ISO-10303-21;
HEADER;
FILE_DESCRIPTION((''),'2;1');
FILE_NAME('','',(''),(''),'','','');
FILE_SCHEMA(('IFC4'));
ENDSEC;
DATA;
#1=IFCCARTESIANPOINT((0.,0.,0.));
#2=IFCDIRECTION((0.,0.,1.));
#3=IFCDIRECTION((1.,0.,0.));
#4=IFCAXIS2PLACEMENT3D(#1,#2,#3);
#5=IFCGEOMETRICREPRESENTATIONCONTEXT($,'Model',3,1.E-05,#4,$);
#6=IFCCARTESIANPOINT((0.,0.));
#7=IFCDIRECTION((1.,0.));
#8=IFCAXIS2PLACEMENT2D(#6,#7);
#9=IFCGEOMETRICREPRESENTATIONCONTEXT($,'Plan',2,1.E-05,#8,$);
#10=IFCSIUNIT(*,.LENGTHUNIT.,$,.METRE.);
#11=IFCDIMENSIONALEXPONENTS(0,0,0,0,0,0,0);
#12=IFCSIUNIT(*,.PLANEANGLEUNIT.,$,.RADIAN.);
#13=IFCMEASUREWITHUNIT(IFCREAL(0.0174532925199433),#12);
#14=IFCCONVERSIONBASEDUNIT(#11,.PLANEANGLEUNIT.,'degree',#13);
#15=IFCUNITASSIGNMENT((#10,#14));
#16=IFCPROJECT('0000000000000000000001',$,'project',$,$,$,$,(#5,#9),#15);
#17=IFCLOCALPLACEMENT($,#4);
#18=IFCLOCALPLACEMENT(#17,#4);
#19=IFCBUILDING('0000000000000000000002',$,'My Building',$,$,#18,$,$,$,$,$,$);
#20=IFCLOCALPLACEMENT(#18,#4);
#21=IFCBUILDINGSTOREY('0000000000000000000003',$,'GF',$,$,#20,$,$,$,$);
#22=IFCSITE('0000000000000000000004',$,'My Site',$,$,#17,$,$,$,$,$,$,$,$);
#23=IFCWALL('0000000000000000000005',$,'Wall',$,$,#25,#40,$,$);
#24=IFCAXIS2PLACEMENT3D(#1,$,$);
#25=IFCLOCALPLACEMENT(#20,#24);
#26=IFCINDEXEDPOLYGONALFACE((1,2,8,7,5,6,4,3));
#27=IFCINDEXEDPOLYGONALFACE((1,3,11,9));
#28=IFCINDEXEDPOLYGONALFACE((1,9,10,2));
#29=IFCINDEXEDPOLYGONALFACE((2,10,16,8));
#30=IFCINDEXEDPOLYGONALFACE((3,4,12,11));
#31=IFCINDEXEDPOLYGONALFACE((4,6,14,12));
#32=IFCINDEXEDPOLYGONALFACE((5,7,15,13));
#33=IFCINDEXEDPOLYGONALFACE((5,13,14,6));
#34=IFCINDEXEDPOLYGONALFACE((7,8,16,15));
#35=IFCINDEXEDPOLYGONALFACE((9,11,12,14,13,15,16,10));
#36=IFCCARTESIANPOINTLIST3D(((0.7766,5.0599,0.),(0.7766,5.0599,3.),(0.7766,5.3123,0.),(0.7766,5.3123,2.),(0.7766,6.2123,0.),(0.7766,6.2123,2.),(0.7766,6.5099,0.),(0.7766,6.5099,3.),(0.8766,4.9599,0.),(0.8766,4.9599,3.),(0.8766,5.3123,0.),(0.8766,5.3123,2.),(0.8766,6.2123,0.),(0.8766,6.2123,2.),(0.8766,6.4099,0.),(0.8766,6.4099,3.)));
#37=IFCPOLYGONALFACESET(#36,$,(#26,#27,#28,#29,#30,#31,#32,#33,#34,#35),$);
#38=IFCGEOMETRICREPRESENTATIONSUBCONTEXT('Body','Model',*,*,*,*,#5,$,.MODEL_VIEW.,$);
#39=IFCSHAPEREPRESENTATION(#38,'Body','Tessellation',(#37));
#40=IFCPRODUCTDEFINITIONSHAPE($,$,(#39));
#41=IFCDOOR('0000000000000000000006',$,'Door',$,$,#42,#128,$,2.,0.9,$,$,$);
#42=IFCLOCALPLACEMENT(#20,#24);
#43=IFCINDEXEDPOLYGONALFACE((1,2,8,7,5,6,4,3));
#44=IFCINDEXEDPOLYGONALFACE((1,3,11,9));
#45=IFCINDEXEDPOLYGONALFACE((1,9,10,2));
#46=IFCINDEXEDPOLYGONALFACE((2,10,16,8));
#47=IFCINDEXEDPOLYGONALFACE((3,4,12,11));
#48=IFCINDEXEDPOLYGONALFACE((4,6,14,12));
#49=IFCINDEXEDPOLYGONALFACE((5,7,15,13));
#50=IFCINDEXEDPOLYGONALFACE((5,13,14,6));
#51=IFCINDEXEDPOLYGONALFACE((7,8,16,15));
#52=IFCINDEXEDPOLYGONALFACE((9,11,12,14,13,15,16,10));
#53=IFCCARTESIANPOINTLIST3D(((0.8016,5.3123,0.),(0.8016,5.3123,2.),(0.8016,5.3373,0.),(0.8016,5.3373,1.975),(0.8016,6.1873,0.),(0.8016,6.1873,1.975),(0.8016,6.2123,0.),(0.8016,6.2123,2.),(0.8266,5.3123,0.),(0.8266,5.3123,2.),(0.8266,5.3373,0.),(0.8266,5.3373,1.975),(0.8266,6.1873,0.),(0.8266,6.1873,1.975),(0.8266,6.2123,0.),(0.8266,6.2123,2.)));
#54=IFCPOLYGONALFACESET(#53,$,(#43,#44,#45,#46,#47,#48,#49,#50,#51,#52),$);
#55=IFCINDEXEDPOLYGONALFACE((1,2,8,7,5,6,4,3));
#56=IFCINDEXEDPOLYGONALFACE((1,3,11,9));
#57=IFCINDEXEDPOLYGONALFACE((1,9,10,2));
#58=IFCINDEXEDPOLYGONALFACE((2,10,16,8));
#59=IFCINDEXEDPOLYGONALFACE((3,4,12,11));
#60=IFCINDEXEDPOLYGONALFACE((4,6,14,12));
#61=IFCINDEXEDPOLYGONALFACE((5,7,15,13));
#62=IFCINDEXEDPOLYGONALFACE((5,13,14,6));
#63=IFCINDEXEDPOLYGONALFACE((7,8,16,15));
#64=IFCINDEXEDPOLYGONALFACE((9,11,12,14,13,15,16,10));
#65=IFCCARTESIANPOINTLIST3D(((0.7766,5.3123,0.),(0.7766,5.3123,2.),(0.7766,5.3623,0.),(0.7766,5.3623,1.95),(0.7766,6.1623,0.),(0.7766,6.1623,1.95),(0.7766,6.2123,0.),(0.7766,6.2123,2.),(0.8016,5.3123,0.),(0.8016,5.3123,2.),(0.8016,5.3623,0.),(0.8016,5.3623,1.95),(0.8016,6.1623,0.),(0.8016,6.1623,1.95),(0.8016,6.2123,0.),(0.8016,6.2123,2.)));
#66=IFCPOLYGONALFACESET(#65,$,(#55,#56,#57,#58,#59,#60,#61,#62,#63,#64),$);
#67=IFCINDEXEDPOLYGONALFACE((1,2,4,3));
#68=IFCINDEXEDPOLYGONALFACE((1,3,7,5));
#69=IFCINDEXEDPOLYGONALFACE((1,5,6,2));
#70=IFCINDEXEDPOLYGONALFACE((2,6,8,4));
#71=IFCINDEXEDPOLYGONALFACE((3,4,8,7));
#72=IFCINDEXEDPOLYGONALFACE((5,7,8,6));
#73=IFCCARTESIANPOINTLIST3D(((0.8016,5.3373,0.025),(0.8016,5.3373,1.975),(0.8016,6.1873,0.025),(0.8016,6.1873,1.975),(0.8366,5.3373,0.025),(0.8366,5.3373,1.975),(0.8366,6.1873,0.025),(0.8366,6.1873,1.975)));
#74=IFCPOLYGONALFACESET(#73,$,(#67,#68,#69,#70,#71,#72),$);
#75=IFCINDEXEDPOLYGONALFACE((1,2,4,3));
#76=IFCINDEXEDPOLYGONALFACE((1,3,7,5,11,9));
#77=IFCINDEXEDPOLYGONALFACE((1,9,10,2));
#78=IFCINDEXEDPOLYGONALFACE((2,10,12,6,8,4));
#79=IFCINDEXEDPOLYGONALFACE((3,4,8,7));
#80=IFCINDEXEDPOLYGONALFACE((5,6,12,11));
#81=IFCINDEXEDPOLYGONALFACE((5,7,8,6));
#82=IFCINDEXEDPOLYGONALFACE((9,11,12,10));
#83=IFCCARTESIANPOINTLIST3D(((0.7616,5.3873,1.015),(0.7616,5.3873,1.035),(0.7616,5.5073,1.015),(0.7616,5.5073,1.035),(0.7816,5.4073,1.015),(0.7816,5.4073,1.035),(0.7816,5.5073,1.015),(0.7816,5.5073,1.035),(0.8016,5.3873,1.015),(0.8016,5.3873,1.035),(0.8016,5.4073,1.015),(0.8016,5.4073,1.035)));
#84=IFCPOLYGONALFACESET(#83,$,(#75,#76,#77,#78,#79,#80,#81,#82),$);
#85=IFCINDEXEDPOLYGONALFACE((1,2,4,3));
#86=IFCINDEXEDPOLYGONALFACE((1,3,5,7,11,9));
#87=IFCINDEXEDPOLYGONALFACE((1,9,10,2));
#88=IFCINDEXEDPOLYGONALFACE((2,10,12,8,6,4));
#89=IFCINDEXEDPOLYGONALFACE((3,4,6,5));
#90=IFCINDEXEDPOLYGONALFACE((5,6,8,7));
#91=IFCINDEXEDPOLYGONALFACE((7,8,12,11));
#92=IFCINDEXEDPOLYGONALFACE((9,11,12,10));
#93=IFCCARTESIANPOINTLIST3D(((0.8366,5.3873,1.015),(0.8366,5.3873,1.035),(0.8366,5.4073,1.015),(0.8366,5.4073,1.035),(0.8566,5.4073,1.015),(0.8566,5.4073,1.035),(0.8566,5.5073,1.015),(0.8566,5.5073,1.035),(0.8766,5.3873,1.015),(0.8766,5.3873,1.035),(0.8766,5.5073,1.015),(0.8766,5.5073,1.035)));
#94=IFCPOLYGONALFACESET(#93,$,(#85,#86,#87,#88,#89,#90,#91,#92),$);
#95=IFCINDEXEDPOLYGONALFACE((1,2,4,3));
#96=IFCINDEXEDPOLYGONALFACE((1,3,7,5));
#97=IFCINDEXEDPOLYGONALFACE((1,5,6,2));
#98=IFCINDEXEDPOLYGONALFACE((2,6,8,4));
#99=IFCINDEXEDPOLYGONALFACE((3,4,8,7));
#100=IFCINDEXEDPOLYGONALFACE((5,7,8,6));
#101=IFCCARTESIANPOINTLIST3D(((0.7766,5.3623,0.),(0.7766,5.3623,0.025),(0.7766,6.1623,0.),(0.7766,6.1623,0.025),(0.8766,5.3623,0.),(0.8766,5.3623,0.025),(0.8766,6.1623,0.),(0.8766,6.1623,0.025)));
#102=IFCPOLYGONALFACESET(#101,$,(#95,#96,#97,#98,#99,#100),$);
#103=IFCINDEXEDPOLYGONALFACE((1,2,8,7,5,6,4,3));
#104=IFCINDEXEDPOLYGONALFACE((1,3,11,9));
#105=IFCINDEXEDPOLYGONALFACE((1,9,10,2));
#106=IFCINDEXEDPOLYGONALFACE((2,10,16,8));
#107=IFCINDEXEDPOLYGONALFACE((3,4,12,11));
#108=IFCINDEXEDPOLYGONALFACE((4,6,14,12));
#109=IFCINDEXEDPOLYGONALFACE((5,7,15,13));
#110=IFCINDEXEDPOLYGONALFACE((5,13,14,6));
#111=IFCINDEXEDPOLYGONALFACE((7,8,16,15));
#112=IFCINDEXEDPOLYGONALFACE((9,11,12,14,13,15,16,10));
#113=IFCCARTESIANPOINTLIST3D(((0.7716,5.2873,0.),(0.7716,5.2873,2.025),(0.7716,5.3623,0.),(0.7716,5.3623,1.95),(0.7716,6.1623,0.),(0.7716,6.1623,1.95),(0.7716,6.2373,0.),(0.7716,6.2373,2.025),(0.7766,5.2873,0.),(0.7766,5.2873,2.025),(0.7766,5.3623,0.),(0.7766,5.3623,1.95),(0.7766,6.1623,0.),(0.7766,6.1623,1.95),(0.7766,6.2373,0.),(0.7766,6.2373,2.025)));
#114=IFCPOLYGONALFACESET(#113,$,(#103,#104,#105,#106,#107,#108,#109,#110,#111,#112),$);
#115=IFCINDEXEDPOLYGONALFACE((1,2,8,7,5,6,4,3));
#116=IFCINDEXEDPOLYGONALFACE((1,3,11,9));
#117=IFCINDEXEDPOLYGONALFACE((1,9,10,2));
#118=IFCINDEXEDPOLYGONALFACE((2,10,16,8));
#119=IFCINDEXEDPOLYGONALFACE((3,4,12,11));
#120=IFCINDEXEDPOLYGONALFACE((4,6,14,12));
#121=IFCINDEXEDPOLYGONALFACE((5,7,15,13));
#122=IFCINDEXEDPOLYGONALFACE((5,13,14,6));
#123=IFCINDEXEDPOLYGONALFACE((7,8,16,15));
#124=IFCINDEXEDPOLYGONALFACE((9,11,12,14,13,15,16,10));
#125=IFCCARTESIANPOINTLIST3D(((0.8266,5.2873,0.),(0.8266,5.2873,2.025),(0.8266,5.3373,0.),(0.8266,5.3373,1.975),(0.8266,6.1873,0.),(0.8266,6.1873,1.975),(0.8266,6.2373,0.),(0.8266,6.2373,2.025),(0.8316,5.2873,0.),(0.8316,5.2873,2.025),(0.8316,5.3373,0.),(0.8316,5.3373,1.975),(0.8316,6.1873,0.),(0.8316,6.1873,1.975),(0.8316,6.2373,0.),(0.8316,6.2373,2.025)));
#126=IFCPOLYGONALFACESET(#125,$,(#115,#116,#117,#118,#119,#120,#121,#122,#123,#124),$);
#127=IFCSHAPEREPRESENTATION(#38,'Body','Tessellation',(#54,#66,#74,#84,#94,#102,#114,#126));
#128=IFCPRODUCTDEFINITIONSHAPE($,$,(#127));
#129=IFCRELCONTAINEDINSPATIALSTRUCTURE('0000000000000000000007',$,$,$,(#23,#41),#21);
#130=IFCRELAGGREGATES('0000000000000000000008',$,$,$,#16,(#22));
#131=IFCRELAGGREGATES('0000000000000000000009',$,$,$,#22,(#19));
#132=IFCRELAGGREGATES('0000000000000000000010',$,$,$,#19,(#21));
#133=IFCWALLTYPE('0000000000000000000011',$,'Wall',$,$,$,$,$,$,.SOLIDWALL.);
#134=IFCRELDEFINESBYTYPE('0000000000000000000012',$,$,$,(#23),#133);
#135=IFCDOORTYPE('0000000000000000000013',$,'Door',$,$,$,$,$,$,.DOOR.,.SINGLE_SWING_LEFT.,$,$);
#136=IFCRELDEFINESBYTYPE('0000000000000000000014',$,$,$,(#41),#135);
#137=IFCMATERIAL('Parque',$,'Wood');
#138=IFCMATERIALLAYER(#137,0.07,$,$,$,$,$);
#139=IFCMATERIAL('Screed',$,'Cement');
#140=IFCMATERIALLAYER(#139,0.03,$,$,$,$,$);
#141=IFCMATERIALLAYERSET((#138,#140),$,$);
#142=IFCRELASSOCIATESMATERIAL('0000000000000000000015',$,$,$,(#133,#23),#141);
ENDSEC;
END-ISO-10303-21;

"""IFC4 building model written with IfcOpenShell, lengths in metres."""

from ifc_helpers import new_model, entity, si_unit, converted_unit, frame, origin_with_axes, origin_2d_with_axis, place, context, subcontext, project, spatial, line, indexed_curve, outline, extrude, shape, source, transform, mapped, material, layer, layer_set, layer_usage, type_object, type_shapes, element, fill, save


model = new_model("IFC4")

# Units and contexts
model_context = context("Model", 3, precision=1e-05, world=origin_with_axes())
plan_context = context("Plan", 2, precision=1e-05, world=origin_2d_with_axis())
body_context_1 = subcontext(model_context, "Body", "Model", "MODEL_VIEW")
body_context_2 = subcontext(plan_context, "Body", "Plan", "PLAN_VIEW")
ifc_project = project(units=[si_unit("LENGTHUNIT", "METRE"), converted_unit("PLANEANGLEUNIT", "degree", entity("IfcReal", 0.0174532925199433), si_unit("PLANEANGLEUNIT", "RADIAN"), dimensions=[0, 0, 0, 0, 0, 0, 0])], contexts=[model_context, plan_context])

# Site, building, storey
site_placement = place(None, origin_with_axes())
site = spatial("IfcSite", under=ifc_project, at=site_placement, Name="My Site")
building_placement = place(site_placement, origin_with_axes())
building = spatial("IfcBuilding", under=site, at=building_placement, Name="My Building")
storey_placement = place(building_placement, origin_with_axes())
storey = spatial("IfcBuildingStorey", under=building, at=storey_placement, Name="GF")

# Shared definitions
ifc_material_1 = material(Name="Parque", Category="Wood")
ifc_layer_1 = layer(ifc_material_1, 0.07)
ifc_material_2 = material(Name="Screed", Category="Cement")
ifc_layer_2 = layer(ifc_material_2, 0.03)
ifc_layer_set_1 = layer_set([ifc_layer_1, ifc_layer_2])
wall_type = type_object("IfcWallType", Name="Wall", PredefinedType="SOLIDWALL", material=ifc_layer_set_1)
shared_shape_1 = source(origin_with_axes(), body_context_1, "Body", "SweptSolid", [
    extrude(outline(indexed_curve([(0.0, 0.0), (0.9, 0.0), (0.9, 2.0), (0.0, 2.0)], segments=[line(1, 2, 3, 4, 1)])), frame((0.0, -0.6, 0.0), z_axis=(0.0, -1.0, 0.0), x_axis=(1.0, 0.0, 0.0)), (0.0, 0.0, -1.0), 1.2),
])
door_type = type_object("IfcDoorType", Name="Door", OperationType="SINGLE_SWING_LEFT", PredefinedType="DOOR")
shared_shape_2 = source(origin_with_axes(), body_context_1, "Body", "SweptSolid", [
    extrude(outline(indexed_curve([(0.0, 0.0), (0.0, 2.0), (0.9, 2.0), (0.9, 0.0), (0.875, 0.0), (0.875, 1.975), (0.025, 1.975), (0.025, 0.0)], segments=[line(1, 2, 3, 4, 5, 6, 7, 8, 1)])), frame((0.0, 0.025, 0.0), z_axis=(0.0, -1.0, 0.0), x_axis=(1.0, 0.0, 0.0)), (0.0, 0.0, -1.0), 0.025),
    extrude(outline(indexed_curve([(0.0, 0.0), (0.0, 2.0), (0.9, 2.0), (0.9, 0.0), (0.85, 0.0), (0.85, 1.95), (0.05, 1.95), (0.05, 0.0)], segments=[line(1, 2, 3, 4, 5, 6, 7, 8, 1)])), frame((0.0, 0.0, 0.0), z_axis=(0.0, -1.0, 0.0), x_axis=(1.0, 0.0, 0.0)), (0.0, 0.0, -1.0), 0.025),
    extrude(outline(indexed_curve([(0.0, 0.0), (0.85, 0.0), (0.85, 0.035), (0.0, 0.035)], segments=[line(1, 2, 3, 4, 1)])), frame((0.025, 0.025, 0.025), z_axis=(0.0, 0.0, 1.0), x_axis=(1.0, 0.0, 0.0)), (0.0, 0.0, 1.0), 1.95),
    extrude(outline(indexed_curve([(0.0, 0.0), (0.0, -0.04), (-0.12, -0.04), (-0.12, -0.02), (-0.02, -0.02), (-0.02, 0.0)], segments=[line(1, 2, 3, 4, 5, 6, 1)])), frame((0.825, 0.025, 1.015), z_axis=(0.0, 0.0, 1.0), x_axis=(1.0, 0.0, 0.0)), (0.0, 0.0, 1.0), 0.02),
    extrude(outline(indexed_curve([(0.0, 0.0), (0.0, 0.04), (-0.12, 0.04), (-0.12, 0.02), (-0.02, 0.02), (-0.02, 0.0)], segments=[line(1, 2, 3, 4, 5, 6, 1)])), frame((0.825, 0.06, 1.015), z_axis=(0.0, 0.0, 1.0), x_axis=(1.0, 0.0, 0.0)), (0.0, 0.0, 1.0), 0.02),
    extrude(outline(indexed_curve([(0.0, 0.0), (0.8, 0.0), (0.8, 0.1), (0.0, 0.1)], segments=[line(1, 2, 3, 4, 1)])), frame((0.05, 0.0, 0.0), z_axis=(0.0, 0.0, 1.0), x_axis=(1.0, 0.0, 0.0)), (0.0, 0.0, 1.0), 0.025),
    extrude(outline(indexed_curve([(0.0, 0.0), (0.0, 2.025), (0.95, 2.025), (0.95, 0.0), (0.875, 0.0), (0.875, 1.95), (0.075, 1.95), (0.075, 0.0)], segments=[line(1, 2, 3, 4, 5, 6, 7, 8, 1)])), frame((-0.025, -0.005, 0.0), z_axis=(0.0, -1.0, 0.0), x_axis=(1.0, 0.0, 0.0)), (0.0, 0.0, -1.0), 0.005),
    extrude(outline(indexed_curve([(0.0, 0.0), (0.0, 2.025), (0.95, 2.025), (0.95, 0.0), (0.9, 0.0), (0.9, 1.975), (0.05, 1.975), (0.05, 0.0)], segments=[line(1, 2, 3, 4, 5, 6, 7, 8, 1)])), frame((-0.025, 0.05, 0.0), z_axis=(0.0, -1.0, 0.0), x_axis=(1.0, 0.0, 0.0)), (0.0, 0.0, -1.0), 0.005),
])
shared_shape_3 = source(origin_with_axes(), body_context_2, "Body", "Curve2D", [
    entity("IfcIndexedPolyCurve", entity("IfcCartesianPointList2D", [[0.0, 0.0], [0.0, 0.05], [0.025, 0.05], [0.025, 0.025], [0.05, 0.025], [0.05, 0.0]]), [entity("IfcLineIndex", [1, 2, 3, 4, 5, 6, 1])]),
    entity("IfcIndexedPolyCurve", entity("IfcCartesianPointList2D", [[0.9, 0.0], [0.9, 0.05], [0.875, 0.05], [0.875, 0.025], [0.85, 0.025], [0.85, 0.0]]), [entity("IfcLineIndex", [1, 2, 3, 4, 5, 6, 1])]),
    entity("IfcTrimmedCurve", entity("IfcEllipse", entity("IfcAxis2Placement2D", entity("IfcCartesianPoint", [0.06, 0.05]), entity("IfcDirection", [1.0, 0.0])), 0.815, 0.85), [entity("IfcCartesianPoint", [0.875, 0.05])], [entity("IfcCartesianPoint", [0.06, 0.9])], True, "CARTESIAN"),
    entity("IfcIndexedPolyCurve", entity("IfcCartesianPointList2D", [[0.025, 0.05], [0.06, 0.05], [0.06, 0.9], [0.025, 0.9]]), [entity("IfcLineIndex", [1, 2, 3, 4, 1])]),
])
type_shapes(door_type, [shared_shape_2, shared_shape_3])

# Wall, opening, door
ifc_layer_usage_1 = layer_usage(ifc_layer_set_1, "AXIS2", "POSITIVE", 0.0)
wall_1_placement = place(storey_placement, frame((0.7766, 6.5099, 0.0), z_axis=(0.0, 0.0, 1.0), x_axis=(0.0, -1.0, 0.0)))
wall_1 = element("IfcWall", 1, at=wall_1_placement, inside=storey, type_object=wall_type, material=ifc_layer_usage_1, Name="Wall", context=body_context_1, shape_type="SweptSolid", body=[
    extrude(outline(indexed_curve([(0.0, 0.0), (0.1, 0.1), (1.55, 0.1), (1.45, 0.0)], segments=[line(1, 2, 3, 4, 1)])), origin_with_axes(), (0.0, 0.0, 1.0), 3.0),
])
opening_1_placement = place(wall_1_placement, frame((0.2976, 0.0, 0.0), z_axis=(0.0, 0.0, 1.0), x_axis=(1.0, 0.0, 0.0)))
opening_1 = element("IfcOpeningElement", 2, at=opening_1_placement, cuts=wall_1, PredefinedType="OPENING", context=body_context_1, shape_type="MappedRepresentation", body=[
    mapped(shared_shape_1, transform((0.0, 0.0, 0.0), x_axis=(1.0, 0.0, 0.0), y_axis=(0.0, 1.0, 0.0), z_axis=(0.0, 0.0, 1.0), scale=1.0)),
])
door_1_placement = place(opening_1_placement, frame((0.0, 0.0, 0.0), z_axis=(0.0, 0.0, 1.0), x_axis=(1.0, 0.0, 0.0)))
door_1 = element("IfcDoor", 3, at=door_1_placement, inside=storey, type_object=door_type, Name="Door", OverallHeight=2.0, OverallWidth=0.9, shapes=[
    shape(body_context_1, "Body", "MappedRepresentation", [mapped(shared_shape_2, transform((0.0, 0.0, 0.0), x_axis=(1.0, 0.0, 0.0), y_axis=(0.0, 1.0, 0.0), z_axis=(0.0, 0.0, 1.0), scale=1.0))]),
    shape(body_context_2, "Body", "MappedRepresentation", [mapped(shared_shape_3, transform((0.0, 0.0, 0.0), x_axis=(1.0, 0.0, 0.0), y_axis=(0.0, 1.0, 0.0), z_axis=(0.0, 0.0, 1.0), scale=1.0))]),
])
fill(opening_1, door_1)

save(model, "model.ifc")
